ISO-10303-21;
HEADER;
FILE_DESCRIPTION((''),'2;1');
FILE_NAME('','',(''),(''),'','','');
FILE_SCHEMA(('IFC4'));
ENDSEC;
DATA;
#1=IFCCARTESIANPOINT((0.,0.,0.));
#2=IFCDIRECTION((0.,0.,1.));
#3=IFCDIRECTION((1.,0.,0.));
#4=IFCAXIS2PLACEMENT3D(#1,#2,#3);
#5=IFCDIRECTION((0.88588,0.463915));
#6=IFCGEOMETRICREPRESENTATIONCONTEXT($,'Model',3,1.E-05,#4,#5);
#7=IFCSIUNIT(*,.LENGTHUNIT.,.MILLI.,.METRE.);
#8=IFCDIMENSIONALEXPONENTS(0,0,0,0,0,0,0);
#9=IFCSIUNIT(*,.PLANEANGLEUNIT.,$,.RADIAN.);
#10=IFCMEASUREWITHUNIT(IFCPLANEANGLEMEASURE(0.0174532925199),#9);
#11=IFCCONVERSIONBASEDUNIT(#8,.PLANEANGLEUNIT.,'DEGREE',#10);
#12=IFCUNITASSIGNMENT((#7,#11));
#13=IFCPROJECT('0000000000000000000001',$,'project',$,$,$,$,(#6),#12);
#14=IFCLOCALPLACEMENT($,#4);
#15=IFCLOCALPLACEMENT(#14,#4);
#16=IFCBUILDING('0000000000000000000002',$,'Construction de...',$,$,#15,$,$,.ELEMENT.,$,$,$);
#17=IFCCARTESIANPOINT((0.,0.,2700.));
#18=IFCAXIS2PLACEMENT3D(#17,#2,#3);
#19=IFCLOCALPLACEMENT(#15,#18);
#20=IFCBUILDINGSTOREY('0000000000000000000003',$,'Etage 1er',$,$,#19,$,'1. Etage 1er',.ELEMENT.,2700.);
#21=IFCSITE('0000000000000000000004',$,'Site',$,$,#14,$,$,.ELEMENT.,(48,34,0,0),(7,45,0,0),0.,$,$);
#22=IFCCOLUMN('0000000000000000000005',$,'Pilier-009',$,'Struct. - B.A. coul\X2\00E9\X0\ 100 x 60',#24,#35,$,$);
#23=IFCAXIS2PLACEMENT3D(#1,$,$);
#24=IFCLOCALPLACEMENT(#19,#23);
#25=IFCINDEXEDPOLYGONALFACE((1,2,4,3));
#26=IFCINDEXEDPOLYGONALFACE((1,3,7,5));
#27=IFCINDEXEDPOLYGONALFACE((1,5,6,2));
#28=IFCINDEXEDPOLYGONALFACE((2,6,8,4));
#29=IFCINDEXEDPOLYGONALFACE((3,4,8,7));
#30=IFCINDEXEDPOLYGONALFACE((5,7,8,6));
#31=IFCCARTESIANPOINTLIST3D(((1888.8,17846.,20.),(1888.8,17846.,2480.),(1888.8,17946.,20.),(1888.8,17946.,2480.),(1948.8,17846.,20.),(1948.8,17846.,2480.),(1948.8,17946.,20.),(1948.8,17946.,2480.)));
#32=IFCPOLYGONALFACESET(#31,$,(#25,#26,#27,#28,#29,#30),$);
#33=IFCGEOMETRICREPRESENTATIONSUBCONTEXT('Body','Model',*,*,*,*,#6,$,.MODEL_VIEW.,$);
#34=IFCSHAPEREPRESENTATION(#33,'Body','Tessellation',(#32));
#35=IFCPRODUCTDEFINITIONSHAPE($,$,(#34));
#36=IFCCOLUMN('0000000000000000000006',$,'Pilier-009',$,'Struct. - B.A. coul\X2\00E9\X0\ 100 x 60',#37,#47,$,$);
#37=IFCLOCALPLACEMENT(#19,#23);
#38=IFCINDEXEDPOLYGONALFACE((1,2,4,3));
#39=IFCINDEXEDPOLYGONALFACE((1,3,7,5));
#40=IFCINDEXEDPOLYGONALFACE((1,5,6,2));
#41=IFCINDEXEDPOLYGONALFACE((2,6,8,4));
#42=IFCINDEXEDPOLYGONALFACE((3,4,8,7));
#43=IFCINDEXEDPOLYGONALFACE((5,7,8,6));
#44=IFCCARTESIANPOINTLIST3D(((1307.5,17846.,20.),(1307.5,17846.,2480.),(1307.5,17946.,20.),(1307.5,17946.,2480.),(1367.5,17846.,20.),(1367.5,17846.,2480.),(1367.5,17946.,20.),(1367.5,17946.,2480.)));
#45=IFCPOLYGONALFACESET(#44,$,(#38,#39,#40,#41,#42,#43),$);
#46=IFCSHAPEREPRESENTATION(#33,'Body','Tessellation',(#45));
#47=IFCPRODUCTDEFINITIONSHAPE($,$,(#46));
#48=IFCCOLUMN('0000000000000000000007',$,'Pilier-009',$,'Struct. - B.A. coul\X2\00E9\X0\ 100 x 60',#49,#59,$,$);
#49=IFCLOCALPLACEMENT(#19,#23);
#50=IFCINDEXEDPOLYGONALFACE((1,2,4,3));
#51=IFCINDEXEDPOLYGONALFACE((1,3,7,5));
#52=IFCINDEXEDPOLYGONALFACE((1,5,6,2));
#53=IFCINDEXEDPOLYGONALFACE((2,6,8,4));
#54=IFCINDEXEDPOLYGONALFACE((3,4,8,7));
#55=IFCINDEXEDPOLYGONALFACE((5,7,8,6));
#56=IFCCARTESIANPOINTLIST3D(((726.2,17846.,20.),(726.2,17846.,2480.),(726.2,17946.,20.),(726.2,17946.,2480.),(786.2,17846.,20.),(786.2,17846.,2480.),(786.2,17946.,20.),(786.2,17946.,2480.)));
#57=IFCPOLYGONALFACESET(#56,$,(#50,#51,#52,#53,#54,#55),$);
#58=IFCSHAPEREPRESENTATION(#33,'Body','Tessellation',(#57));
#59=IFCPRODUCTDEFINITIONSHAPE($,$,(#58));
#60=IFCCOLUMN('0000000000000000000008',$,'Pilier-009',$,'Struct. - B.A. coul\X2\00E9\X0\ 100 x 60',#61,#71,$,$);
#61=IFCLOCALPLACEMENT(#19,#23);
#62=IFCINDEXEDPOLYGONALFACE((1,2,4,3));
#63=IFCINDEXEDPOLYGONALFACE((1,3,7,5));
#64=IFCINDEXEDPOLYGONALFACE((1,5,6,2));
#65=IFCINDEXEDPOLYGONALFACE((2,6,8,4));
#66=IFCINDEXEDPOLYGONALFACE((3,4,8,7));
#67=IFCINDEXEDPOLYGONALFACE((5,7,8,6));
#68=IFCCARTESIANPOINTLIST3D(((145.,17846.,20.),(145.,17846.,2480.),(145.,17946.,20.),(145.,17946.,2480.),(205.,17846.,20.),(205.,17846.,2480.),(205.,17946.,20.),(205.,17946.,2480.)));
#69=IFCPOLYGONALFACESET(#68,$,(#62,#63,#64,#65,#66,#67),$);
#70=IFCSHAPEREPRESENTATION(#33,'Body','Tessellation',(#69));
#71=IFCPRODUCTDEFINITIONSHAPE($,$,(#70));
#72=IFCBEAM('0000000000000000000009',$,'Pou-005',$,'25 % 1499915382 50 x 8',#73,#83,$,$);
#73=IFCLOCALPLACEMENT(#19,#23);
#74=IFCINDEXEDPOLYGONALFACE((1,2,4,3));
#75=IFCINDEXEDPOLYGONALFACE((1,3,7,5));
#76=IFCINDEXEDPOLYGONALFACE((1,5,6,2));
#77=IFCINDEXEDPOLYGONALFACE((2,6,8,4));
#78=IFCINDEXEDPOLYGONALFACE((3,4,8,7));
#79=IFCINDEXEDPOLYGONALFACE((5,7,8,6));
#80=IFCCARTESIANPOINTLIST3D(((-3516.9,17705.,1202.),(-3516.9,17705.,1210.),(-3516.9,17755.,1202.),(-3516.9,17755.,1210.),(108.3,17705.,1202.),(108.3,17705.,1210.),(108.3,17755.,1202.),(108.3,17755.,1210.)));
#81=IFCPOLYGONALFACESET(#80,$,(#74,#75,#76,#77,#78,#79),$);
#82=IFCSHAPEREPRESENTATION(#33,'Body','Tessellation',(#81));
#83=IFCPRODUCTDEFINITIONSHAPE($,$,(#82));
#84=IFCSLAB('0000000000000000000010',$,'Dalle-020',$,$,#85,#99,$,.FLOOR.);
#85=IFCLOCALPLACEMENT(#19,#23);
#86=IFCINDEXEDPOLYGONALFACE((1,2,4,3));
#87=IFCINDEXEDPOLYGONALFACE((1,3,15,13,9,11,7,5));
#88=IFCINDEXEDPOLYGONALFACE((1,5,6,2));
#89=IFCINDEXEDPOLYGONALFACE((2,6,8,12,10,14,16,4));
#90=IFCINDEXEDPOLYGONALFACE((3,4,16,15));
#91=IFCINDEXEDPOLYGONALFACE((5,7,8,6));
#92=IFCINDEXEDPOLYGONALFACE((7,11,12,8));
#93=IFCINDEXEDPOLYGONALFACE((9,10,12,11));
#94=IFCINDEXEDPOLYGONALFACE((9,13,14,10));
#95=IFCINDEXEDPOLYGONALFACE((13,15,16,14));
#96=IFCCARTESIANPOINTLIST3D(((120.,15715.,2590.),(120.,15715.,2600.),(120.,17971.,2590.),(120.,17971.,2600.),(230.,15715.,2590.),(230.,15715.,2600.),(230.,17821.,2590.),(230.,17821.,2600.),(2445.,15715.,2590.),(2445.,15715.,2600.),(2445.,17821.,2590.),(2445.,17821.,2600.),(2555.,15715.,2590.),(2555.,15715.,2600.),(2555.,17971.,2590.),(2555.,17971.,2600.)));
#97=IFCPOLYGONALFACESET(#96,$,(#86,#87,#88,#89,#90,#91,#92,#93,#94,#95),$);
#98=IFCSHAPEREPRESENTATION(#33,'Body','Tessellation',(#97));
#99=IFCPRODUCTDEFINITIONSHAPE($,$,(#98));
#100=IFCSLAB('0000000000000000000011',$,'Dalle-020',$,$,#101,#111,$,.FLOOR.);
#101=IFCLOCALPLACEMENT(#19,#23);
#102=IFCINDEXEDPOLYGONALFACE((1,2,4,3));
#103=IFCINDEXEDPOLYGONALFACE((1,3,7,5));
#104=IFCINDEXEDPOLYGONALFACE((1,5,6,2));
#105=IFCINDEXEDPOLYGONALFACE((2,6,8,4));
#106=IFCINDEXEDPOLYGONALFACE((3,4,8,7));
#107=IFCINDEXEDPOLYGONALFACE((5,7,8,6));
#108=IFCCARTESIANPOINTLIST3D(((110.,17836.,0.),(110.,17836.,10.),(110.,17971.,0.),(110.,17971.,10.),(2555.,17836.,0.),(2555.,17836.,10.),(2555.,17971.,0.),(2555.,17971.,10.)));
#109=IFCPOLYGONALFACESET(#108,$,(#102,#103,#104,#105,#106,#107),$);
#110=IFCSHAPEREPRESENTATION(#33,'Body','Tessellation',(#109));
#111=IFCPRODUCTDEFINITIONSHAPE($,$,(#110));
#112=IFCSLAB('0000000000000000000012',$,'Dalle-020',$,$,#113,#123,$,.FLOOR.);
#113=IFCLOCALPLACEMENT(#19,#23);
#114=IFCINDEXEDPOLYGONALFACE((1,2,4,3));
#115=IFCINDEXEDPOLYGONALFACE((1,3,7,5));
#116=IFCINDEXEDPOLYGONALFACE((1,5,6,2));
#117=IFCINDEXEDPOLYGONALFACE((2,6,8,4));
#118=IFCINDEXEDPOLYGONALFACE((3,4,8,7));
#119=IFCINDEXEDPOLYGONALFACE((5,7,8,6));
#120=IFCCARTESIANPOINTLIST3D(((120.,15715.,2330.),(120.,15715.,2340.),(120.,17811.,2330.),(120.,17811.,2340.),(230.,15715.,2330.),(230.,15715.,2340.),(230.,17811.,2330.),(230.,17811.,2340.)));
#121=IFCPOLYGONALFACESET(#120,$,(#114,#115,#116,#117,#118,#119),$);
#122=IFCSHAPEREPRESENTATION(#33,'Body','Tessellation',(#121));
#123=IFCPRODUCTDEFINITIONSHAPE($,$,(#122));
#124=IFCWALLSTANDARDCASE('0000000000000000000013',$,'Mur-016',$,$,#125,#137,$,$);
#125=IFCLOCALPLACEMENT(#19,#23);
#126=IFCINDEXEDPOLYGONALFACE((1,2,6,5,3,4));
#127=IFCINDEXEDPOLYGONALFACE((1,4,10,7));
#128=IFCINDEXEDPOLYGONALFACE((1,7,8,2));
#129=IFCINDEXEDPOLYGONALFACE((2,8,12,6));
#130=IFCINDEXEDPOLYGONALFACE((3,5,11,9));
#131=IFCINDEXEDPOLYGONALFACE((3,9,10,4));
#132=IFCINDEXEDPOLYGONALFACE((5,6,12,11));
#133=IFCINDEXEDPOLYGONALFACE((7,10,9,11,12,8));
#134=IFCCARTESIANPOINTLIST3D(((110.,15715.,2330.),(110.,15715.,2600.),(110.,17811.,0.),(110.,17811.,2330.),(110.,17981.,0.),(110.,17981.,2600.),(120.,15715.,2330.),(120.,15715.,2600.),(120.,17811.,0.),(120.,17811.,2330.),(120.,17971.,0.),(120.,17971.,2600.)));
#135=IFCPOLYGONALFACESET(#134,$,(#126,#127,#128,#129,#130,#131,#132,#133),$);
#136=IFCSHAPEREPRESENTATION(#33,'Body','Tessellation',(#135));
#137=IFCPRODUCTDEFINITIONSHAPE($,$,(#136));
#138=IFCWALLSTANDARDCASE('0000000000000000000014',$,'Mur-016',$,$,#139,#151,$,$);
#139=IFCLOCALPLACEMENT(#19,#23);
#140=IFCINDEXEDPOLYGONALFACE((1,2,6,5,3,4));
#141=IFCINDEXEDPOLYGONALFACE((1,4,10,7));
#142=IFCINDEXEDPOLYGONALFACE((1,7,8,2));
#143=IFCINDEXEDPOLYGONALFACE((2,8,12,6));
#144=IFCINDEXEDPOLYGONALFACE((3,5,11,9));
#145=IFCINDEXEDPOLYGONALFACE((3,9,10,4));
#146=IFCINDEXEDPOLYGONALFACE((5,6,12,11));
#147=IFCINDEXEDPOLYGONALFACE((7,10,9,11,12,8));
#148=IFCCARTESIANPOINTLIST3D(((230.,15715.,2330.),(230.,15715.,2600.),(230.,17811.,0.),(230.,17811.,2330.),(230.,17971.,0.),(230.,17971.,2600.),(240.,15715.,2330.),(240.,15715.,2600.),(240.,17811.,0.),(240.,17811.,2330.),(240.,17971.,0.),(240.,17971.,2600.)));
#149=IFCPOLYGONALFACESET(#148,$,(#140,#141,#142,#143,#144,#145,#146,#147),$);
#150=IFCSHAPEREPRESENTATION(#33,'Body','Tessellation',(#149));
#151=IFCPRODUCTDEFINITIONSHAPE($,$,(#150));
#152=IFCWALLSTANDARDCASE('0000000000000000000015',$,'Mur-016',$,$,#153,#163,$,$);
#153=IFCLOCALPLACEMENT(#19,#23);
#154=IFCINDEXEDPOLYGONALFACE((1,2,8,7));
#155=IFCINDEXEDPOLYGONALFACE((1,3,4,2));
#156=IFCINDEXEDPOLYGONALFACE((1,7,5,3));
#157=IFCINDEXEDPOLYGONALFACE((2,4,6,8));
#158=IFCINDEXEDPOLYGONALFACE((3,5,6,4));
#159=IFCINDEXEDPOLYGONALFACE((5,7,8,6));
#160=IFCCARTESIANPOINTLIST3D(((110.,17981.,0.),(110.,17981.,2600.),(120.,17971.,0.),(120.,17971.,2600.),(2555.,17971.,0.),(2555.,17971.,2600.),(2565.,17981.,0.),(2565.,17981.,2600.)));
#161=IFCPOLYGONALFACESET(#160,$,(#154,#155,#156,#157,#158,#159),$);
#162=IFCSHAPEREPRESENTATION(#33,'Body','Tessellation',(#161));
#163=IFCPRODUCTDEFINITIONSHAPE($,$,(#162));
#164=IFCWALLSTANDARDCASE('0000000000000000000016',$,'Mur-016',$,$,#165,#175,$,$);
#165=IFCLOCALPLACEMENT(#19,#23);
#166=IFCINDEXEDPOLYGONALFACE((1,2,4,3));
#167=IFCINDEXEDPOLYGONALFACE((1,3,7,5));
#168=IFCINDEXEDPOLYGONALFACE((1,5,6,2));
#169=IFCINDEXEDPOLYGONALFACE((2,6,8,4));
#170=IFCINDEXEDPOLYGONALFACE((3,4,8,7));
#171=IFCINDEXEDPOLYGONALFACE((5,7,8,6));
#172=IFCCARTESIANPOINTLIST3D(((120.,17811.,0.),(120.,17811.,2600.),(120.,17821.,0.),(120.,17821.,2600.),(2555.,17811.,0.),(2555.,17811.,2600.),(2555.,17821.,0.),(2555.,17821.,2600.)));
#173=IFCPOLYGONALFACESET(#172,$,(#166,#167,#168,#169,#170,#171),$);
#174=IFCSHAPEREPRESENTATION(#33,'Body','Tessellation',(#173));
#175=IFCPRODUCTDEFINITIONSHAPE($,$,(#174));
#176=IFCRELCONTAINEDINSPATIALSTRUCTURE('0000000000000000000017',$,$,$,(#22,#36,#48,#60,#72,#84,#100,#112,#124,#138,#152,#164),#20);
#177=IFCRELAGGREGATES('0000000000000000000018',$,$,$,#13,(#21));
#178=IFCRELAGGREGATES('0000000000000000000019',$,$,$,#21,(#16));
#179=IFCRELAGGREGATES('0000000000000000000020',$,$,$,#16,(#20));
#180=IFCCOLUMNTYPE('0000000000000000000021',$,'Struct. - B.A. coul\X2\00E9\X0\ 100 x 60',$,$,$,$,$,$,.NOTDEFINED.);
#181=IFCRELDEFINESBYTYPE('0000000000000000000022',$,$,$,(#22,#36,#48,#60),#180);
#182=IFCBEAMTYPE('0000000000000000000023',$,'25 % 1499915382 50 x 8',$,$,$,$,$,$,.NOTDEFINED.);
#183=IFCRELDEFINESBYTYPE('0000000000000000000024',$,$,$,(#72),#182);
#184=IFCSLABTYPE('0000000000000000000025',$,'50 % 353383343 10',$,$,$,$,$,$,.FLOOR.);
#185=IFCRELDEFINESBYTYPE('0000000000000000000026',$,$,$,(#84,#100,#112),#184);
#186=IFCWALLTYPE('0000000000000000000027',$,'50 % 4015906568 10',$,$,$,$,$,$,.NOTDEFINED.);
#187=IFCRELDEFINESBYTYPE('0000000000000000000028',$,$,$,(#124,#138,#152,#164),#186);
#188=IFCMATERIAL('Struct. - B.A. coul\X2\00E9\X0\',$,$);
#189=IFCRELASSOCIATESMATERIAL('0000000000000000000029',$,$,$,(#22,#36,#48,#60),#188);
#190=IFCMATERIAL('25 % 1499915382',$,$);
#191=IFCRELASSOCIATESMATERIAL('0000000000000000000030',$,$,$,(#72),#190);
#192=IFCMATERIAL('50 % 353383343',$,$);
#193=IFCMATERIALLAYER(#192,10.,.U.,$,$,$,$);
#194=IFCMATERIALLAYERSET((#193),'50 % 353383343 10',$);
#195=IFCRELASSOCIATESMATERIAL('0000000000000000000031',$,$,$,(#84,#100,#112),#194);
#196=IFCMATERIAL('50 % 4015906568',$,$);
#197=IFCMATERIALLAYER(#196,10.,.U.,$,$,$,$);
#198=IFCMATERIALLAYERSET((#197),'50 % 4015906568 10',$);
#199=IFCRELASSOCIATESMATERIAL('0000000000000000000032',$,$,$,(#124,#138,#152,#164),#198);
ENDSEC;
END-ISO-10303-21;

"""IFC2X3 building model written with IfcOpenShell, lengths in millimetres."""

from ifc_helpers import new_model, entity, si_unit, converted_unit, direction, frame, frame_2d, origin_with_axes, origin_2d_with_axis, place, context, subcontext, project, spatial, polyline, rectangle, outline, extrude, material, layer, layer_set, layer_usage, type_object, element, save


model = new_model("IFC2X3")

# Units and contexts
model_context = context("Model", 3, precision=1e-05, world=origin_with_axes(), true_north=direction((0.88588, 0.463915)))
body_context = subcontext(model_context, "Body", "Model", "MODEL_VIEW")
ifc_project = project(units=[si_unit("LENGTHUNIT", "METRE", prefix="MILLI"), converted_unit("PLANEANGLEUNIT", "DEGREE", entity("IfcPlaneAngleMeasure", 0.0174532925199), si_unit("PLANEANGLEUNIT", "RADIAN"), dimensions=[0, 0, 0, 0, 0, 0, 0])], contexts=[model_context])

# Site, building, storey
site_placement = place(None, origin_with_axes())
site = spatial("IfcSite", under=ifc_project, at=site_placement, Name="Site", CompositionType="ELEMENT", RefLatitude=(48, 34, 0, 0), RefLongitude=(7, 45, 0, 0), RefElevation=0.0)
building_placement = place(site_placement, origin_with_axes())
building = spatial("IfcBuilding", under=site, at=building_placement, Name="Construction de...", CompositionType="ELEMENT")
storey_placement = place(building_placement, frame((0.0, 0.0, 2700.0), z_axis=(0.0, 0.0, 1.0), x_axis=(1.0, 0.0, 0.0)))
storey = spatial("IfcBuildingStorey", under=building, at=storey_placement, Name="Etage 1er", LongName="1. Etage 1er", CompositionType="ELEMENT", Elevation=2700.0)

# Columns
ifc_material_1 = material(Name="Struct. - B.A. coulé")
column_type_1 = type_object("IfcColumnType", Name="Struct. - B.A. coulé 100 x 60", PredefinedType="NOTDEFINED")
for number, where, z_axis, x_axis, name in (
    (1, (1918.8, 17896.0, 20.0), (0.0, 0.0, 1.0), (0.0, -1.0, 0.0), "Pilier-009"),
    (2, (1337.5, 17896.0, 20.0), (0.0, 0.0, 1.0), (0.0, -1.0, 0.0), "Pilier-009"),
    (3, (756.2, 17896.0, 20.0), (0.0, 0.0, 1.0), (0.0, -1.0, 0.0), "Pilier-009"),
    (4, (175.0, 17896.0, 20.0), (0.0, 0.0, 1.0), (0.0, -1.0, 0.0), "Pilier-009"),
):
    element("IfcColumn", number, at=place(storey_placement, frame(where, z_axis=z_axis, x_axis=x_axis)), inside=storey, type_object=column_type_1, material=ifc_material_1, Name=name, ObjectType="Struct. - B.A. coulé 100 x 60", context=body_context, shape_type="SweptSolid", body=[
        extrude(rectangle(XDim=100.0, YDim=60.0, at=origin_2d_with_axis()), origin_with_axes(), (0.0, 0.0, 1.0), 2460.0),
    ])

# Beam
ifc_material_2 = material(Name="25 % 1499915382")
beam_type = type_object("IfcBeamType", Name="25 % 1499915382 50 x 8", PredefinedType="NOTDEFINED")
beam_placement = place(storey_placement, frame((108.3, 17730.0, 1210.0), z_axis=(0.0, 0.0, 1.0), x_axis=(0.0, 1.0, 0.0)))
element("IfcBeam", 5, at=beam_placement, inside=storey, type_object=beam_type, material=ifc_material_2, Name="Pou-005", ObjectType="25 % 1499915382 50 x 8", context=body_context, shape_type="SweptSolid", body=[
    extrude(rectangle(XDim=8.0, YDim=50.0, at=frame_2d((-4.0, 0.0), x_axis=(1.0, 0.0))), frame((0.0, 0.0, 0.0), z_axis=(0.0, 1.0, 0.0), x_axis=(0.0, 0.0, 1.0)), (0.0, 0.0, 1.0), 3625.2),
])

# Slabs
ifc_material_3 = material(Name="50 % 353383343")
ifc_layer_1 = layer(ifc_material_3, 10.0, ventilated="UNKNOWN")
ifc_layer_set_1 = layer_set([ifc_layer_1], Name="50 % 353383343 10")
ifc_layer_usage_1 = layer_usage(ifc_layer_set_1, "AXIS3", "NEGATIVE", 10.0)
slab_type = type_object("IfcSlabType", Name="50 % 353383343 10", PredefinedType="FLOOR")
slab_1_placement = place(storey_placement, frame((120.0, 17971.0, 2600.0), z_axis=(0.0, 0.0, 1.0), x_axis=(1.0, 0.0, 0.0)))
element("IfcSlab", 6, at=slab_1_placement, inside=storey, type_object=slab_type, material=ifc_layer_usage_1, Name="Dalle-020", PredefinedType="FLOOR", context=body_context, shape_type="SweptSolid", body=[
    extrude(outline(polyline([(0.0, 0.0), (0.0, -2256.0), (110.0, -2256.0), (110.0, -150.0), (2325.0, -150.0), (2325.0, -2256.0), (2435.0, -2256.0), (2435.0, 0.0), (0.0, 0.0)])), frame((0.0, 0.0, -10.0), z_axis=(0.0, 0.0, 1.0), x_axis=(1.0, 0.0, 0.0)), (0.0, 0.0, 1.0), 10.0),
])
ifc_layer_usage_2 = layer_usage(ifc_layer_set_1, "AXIS3", "NEGATIVE", 10.0)
slab_2_placement = place(storey_placement, frame((110.0, 17971.0, 10.0), z_axis=(0.0, 0.0, 1.0), x_axis=(1.0, 0.0, 0.0)))
element("IfcSlab", 7, at=slab_2_placement, inside=storey, type_object=slab_type, material=ifc_layer_usage_2, Name="Dalle-020", PredefinedType="FLOOR", context=body_context, shape_type="SweptSolid", body=[
    extrude(outline(polyline([(0.0, 0.0), (0.0, -135.0), (2445.0, -135.0), (2445.0, 0.0), (0.0, 0.0)])), frame((0.0, 0.0, -10.0), z_axis=(0.0, 0.0, 1.0), x_axis=(1.0, 0.0, 0.0)), (0.0, 0.0, 1.0), 10.0),
])
ifc_layer_usage_3 = layer_usage(ifc_layer_set_1, "AXIS3", "NEGATIVE", 10.0)
slab_3_placement = place(storey_placement, frame((120.0, 17811.0, 2340.0), z_axis=(0.0, 0.0, 1.0), x_axis=(1.0, 0.0, 0.0)))
element("IfcSlab", 8, at=slab_3_placement, inside=storey, type_object=slab_type, material=ifc_layer_usage_3, Name="Dalle-020", PredefinedType="FLOOR", context=body_context, shape_type="SweptSolid", body=[
    extrude(outline(polyline([(0.0, 0.0), (0.0, -2096.0), (110.0, -2096.0), (110.0, 0.0), (0.0, 0.0)])), frame((0.0, 0.0, -10.0), z_axis=(0.0, 0.0, 1.0), x_axis=(1.0, 0.0, 0.0)), (0.0, 0.0, 1.0), 10.0),
])

# Walls, openings
ifc_material_4 = material(Name="50 % 4015906568")
ifc_layer_2 = layer(ifc_material_4, 10.0, ventilated="UNKNOWN")
ifc_layer_set_2 = layer_set([ifc_layer_2], Name="50 % 4015906568 10")
ifc_layer_usage_4 = layer_usage(ifc_layer_set_2, "AXIS2", "POSITIVE", -5.0)
wall_type_1 = type_object("IfcWallType", Name="50 % 4015906568 10", PredefinedType="NOTDEFINED")
wall_1_placement = place(storey_placement, frame((115.0, 17976.0, 0.0), z_axis=(0.0, 0.0, 1.0), x_axis=(0.0, -1.0, 0.0)))
wall_1 = element("IfcWallStandardCase", 9, at=wall_1_placement, inside=storey, type_object=wall_type_1, material=ifc_layer_usage_4, Name="Mur-016", context=body_context, shape_type="SweptSolid", body=[
    extrude(outline(polyline([(-5.0, -5.0), (2261.0, -5.0), (2261.0, 5.0), (5.0, 5.0), (-5.0, -5.0)])), origin_with_axes(), (0.0, 0.0, 1.0), 2600.0),
])
opening_1_placement = place(wall_1_placement, frame((1213.0, 0.0, 0.0), z_axis=(0.0, 0.0, 1.0), x_axis=(1.0, 0.0, 0.0)))
element("IfcOpeningElement", 10, at=opening_1_placement, cuts=wall_1, context=body_context, shape_type="SweptSolid", body=[
    extrude(rectangle(XDim=2096.0, YDim=2330.0, at=origin_2d_with_axis()), frame((0.0, -5.0, 1165.0), z_axis=(0.0, 1.0, 0.0), x_axis=(1.0, 0.0, 0.0)), (0.0, 0.0, -1.0), 10.0),
    extrude(rectangle(XDim=2096.0, YDim=2330.0, at=origin_2d_with_axis()), frame((0.0, -5.0, 1165.0), z_axis=(0.0, -1.0, 0.0), x_axis=(1.0, 0.0, 0.0)), (0.0, 0.0, -1.0), 10.0),
])
ifc_layer_usage_5 = layer_usage(ifc_layer_set_2, "AXIS2", "NEGATIVE", 5.0)
wall_2_placement = place(storey_placement, frame((235.0, 17976.0, 0.0), z_axis=(0.0, 0.0, 1.0), x_axis=(0.0, -1.0, 0.0)))
wall_2 = element("IfcWallStandardCase", 11, at=wall_2_placement, inside=storey, type_object=wall_type_1, material=ifc_layer_usage_5, Name="Mur-016", context=body_context, shape_type="SweptSolid", body=[
    extrude(outline(polyline([(5.0, -5.0), (2261.0, -5.0), (2261.0, 5.0), (5.0, 5.0), (5.0, -5.0)])), origin_with_axes(), (0.0, 0.0, 1.0), 2600.0),
])
opening_2_placement = place(wall_2_placement, frame((1213.0, 0.0, 0.0), z_axis=(0.0, 0.0, 1.0), x_axis=(1.0, 0.0, 0.0)))
element("IfcOpeningElement", 12, at=opening_2_placement, cuts=wall_2, context=body_context, shape_type="SweptSolid", body=[
    extrude(rectangle(XDim=2096.0, YDim=2330.0, at=origin_2d_with_axis()), frame((0.0, 5.0, 1165.0), z_axis=(0.0, -1.0, 0.0), x_axis=(1.0, 0.0, 0.0)), (0.0, 0.0, -1.0), 10.0),
    extrude(rectangle(XDim=2096.0, YDim=2330.0, at=origin_2d_with_axis()), frame((0.0, 5.0, 1165.0), z_axis=(0.0, 1.0, 0.0), x_axis=(1.0, 0.0, 0.0)), (0.0, 0.0, -1.0), 10.0),
])

# Walls
ifc_layer_usage_6 = layer_usage(ifc_layer_set_2, "AXIS2", "NEGATIVE", 5.0)
wall_3_placement = place(storey_placement, frame((115.0, 17976.0, 0.0), z_axis=(0.0, 0.0, 1.0), x_axis=(1.0, 0.0, 0.0)))
element("IfcWallStandardCase", 13, at=wall_3_placement, inside=storey, type_object=wall_type_1, material=ifc_layer_usage_6, Name="Mur-016", context=body_context, shape_type="SweptSolid", body=[
    extrude(outline(polyline([(5.0, -5.0), (2440.0, -5.0), (2450.0, 5.0), (-5.0, 5.0), (5.0, -5.0)])), origin_with_axes(), (0.0, 0.0, 1.0), 2600.0),
])
ifc_layer_usage_7 = layer_usage(ifc_layer_set_2, "AXIS2", "NEGATIVE", 5.0)
wall_4_placement = place(storey_placement, frame((115.0, 17816.0, 0.0), z_axis=(0.0, 0.0, 1.0), x_axis=(1.0, 0.0, 0.0)))
element("IfcWallStandardCase", 14, at=wall_4_placement, inside=storey, type_object=wall_type_1, material=ifc_layer_usage_7, Name="Mur-016", context=body_context, shape_type="SweptSolid", body=[
    extrude(outline(polyline([(5.0, -5.0), (2440.0, -5.0), (2440.0, 5.0), (5.0, 5.0), (5.0, -5.0)])), origin_with_axes(), (0.0, 0.0, 1.0), 2600.0),
])

save(model, "model.ifc")
